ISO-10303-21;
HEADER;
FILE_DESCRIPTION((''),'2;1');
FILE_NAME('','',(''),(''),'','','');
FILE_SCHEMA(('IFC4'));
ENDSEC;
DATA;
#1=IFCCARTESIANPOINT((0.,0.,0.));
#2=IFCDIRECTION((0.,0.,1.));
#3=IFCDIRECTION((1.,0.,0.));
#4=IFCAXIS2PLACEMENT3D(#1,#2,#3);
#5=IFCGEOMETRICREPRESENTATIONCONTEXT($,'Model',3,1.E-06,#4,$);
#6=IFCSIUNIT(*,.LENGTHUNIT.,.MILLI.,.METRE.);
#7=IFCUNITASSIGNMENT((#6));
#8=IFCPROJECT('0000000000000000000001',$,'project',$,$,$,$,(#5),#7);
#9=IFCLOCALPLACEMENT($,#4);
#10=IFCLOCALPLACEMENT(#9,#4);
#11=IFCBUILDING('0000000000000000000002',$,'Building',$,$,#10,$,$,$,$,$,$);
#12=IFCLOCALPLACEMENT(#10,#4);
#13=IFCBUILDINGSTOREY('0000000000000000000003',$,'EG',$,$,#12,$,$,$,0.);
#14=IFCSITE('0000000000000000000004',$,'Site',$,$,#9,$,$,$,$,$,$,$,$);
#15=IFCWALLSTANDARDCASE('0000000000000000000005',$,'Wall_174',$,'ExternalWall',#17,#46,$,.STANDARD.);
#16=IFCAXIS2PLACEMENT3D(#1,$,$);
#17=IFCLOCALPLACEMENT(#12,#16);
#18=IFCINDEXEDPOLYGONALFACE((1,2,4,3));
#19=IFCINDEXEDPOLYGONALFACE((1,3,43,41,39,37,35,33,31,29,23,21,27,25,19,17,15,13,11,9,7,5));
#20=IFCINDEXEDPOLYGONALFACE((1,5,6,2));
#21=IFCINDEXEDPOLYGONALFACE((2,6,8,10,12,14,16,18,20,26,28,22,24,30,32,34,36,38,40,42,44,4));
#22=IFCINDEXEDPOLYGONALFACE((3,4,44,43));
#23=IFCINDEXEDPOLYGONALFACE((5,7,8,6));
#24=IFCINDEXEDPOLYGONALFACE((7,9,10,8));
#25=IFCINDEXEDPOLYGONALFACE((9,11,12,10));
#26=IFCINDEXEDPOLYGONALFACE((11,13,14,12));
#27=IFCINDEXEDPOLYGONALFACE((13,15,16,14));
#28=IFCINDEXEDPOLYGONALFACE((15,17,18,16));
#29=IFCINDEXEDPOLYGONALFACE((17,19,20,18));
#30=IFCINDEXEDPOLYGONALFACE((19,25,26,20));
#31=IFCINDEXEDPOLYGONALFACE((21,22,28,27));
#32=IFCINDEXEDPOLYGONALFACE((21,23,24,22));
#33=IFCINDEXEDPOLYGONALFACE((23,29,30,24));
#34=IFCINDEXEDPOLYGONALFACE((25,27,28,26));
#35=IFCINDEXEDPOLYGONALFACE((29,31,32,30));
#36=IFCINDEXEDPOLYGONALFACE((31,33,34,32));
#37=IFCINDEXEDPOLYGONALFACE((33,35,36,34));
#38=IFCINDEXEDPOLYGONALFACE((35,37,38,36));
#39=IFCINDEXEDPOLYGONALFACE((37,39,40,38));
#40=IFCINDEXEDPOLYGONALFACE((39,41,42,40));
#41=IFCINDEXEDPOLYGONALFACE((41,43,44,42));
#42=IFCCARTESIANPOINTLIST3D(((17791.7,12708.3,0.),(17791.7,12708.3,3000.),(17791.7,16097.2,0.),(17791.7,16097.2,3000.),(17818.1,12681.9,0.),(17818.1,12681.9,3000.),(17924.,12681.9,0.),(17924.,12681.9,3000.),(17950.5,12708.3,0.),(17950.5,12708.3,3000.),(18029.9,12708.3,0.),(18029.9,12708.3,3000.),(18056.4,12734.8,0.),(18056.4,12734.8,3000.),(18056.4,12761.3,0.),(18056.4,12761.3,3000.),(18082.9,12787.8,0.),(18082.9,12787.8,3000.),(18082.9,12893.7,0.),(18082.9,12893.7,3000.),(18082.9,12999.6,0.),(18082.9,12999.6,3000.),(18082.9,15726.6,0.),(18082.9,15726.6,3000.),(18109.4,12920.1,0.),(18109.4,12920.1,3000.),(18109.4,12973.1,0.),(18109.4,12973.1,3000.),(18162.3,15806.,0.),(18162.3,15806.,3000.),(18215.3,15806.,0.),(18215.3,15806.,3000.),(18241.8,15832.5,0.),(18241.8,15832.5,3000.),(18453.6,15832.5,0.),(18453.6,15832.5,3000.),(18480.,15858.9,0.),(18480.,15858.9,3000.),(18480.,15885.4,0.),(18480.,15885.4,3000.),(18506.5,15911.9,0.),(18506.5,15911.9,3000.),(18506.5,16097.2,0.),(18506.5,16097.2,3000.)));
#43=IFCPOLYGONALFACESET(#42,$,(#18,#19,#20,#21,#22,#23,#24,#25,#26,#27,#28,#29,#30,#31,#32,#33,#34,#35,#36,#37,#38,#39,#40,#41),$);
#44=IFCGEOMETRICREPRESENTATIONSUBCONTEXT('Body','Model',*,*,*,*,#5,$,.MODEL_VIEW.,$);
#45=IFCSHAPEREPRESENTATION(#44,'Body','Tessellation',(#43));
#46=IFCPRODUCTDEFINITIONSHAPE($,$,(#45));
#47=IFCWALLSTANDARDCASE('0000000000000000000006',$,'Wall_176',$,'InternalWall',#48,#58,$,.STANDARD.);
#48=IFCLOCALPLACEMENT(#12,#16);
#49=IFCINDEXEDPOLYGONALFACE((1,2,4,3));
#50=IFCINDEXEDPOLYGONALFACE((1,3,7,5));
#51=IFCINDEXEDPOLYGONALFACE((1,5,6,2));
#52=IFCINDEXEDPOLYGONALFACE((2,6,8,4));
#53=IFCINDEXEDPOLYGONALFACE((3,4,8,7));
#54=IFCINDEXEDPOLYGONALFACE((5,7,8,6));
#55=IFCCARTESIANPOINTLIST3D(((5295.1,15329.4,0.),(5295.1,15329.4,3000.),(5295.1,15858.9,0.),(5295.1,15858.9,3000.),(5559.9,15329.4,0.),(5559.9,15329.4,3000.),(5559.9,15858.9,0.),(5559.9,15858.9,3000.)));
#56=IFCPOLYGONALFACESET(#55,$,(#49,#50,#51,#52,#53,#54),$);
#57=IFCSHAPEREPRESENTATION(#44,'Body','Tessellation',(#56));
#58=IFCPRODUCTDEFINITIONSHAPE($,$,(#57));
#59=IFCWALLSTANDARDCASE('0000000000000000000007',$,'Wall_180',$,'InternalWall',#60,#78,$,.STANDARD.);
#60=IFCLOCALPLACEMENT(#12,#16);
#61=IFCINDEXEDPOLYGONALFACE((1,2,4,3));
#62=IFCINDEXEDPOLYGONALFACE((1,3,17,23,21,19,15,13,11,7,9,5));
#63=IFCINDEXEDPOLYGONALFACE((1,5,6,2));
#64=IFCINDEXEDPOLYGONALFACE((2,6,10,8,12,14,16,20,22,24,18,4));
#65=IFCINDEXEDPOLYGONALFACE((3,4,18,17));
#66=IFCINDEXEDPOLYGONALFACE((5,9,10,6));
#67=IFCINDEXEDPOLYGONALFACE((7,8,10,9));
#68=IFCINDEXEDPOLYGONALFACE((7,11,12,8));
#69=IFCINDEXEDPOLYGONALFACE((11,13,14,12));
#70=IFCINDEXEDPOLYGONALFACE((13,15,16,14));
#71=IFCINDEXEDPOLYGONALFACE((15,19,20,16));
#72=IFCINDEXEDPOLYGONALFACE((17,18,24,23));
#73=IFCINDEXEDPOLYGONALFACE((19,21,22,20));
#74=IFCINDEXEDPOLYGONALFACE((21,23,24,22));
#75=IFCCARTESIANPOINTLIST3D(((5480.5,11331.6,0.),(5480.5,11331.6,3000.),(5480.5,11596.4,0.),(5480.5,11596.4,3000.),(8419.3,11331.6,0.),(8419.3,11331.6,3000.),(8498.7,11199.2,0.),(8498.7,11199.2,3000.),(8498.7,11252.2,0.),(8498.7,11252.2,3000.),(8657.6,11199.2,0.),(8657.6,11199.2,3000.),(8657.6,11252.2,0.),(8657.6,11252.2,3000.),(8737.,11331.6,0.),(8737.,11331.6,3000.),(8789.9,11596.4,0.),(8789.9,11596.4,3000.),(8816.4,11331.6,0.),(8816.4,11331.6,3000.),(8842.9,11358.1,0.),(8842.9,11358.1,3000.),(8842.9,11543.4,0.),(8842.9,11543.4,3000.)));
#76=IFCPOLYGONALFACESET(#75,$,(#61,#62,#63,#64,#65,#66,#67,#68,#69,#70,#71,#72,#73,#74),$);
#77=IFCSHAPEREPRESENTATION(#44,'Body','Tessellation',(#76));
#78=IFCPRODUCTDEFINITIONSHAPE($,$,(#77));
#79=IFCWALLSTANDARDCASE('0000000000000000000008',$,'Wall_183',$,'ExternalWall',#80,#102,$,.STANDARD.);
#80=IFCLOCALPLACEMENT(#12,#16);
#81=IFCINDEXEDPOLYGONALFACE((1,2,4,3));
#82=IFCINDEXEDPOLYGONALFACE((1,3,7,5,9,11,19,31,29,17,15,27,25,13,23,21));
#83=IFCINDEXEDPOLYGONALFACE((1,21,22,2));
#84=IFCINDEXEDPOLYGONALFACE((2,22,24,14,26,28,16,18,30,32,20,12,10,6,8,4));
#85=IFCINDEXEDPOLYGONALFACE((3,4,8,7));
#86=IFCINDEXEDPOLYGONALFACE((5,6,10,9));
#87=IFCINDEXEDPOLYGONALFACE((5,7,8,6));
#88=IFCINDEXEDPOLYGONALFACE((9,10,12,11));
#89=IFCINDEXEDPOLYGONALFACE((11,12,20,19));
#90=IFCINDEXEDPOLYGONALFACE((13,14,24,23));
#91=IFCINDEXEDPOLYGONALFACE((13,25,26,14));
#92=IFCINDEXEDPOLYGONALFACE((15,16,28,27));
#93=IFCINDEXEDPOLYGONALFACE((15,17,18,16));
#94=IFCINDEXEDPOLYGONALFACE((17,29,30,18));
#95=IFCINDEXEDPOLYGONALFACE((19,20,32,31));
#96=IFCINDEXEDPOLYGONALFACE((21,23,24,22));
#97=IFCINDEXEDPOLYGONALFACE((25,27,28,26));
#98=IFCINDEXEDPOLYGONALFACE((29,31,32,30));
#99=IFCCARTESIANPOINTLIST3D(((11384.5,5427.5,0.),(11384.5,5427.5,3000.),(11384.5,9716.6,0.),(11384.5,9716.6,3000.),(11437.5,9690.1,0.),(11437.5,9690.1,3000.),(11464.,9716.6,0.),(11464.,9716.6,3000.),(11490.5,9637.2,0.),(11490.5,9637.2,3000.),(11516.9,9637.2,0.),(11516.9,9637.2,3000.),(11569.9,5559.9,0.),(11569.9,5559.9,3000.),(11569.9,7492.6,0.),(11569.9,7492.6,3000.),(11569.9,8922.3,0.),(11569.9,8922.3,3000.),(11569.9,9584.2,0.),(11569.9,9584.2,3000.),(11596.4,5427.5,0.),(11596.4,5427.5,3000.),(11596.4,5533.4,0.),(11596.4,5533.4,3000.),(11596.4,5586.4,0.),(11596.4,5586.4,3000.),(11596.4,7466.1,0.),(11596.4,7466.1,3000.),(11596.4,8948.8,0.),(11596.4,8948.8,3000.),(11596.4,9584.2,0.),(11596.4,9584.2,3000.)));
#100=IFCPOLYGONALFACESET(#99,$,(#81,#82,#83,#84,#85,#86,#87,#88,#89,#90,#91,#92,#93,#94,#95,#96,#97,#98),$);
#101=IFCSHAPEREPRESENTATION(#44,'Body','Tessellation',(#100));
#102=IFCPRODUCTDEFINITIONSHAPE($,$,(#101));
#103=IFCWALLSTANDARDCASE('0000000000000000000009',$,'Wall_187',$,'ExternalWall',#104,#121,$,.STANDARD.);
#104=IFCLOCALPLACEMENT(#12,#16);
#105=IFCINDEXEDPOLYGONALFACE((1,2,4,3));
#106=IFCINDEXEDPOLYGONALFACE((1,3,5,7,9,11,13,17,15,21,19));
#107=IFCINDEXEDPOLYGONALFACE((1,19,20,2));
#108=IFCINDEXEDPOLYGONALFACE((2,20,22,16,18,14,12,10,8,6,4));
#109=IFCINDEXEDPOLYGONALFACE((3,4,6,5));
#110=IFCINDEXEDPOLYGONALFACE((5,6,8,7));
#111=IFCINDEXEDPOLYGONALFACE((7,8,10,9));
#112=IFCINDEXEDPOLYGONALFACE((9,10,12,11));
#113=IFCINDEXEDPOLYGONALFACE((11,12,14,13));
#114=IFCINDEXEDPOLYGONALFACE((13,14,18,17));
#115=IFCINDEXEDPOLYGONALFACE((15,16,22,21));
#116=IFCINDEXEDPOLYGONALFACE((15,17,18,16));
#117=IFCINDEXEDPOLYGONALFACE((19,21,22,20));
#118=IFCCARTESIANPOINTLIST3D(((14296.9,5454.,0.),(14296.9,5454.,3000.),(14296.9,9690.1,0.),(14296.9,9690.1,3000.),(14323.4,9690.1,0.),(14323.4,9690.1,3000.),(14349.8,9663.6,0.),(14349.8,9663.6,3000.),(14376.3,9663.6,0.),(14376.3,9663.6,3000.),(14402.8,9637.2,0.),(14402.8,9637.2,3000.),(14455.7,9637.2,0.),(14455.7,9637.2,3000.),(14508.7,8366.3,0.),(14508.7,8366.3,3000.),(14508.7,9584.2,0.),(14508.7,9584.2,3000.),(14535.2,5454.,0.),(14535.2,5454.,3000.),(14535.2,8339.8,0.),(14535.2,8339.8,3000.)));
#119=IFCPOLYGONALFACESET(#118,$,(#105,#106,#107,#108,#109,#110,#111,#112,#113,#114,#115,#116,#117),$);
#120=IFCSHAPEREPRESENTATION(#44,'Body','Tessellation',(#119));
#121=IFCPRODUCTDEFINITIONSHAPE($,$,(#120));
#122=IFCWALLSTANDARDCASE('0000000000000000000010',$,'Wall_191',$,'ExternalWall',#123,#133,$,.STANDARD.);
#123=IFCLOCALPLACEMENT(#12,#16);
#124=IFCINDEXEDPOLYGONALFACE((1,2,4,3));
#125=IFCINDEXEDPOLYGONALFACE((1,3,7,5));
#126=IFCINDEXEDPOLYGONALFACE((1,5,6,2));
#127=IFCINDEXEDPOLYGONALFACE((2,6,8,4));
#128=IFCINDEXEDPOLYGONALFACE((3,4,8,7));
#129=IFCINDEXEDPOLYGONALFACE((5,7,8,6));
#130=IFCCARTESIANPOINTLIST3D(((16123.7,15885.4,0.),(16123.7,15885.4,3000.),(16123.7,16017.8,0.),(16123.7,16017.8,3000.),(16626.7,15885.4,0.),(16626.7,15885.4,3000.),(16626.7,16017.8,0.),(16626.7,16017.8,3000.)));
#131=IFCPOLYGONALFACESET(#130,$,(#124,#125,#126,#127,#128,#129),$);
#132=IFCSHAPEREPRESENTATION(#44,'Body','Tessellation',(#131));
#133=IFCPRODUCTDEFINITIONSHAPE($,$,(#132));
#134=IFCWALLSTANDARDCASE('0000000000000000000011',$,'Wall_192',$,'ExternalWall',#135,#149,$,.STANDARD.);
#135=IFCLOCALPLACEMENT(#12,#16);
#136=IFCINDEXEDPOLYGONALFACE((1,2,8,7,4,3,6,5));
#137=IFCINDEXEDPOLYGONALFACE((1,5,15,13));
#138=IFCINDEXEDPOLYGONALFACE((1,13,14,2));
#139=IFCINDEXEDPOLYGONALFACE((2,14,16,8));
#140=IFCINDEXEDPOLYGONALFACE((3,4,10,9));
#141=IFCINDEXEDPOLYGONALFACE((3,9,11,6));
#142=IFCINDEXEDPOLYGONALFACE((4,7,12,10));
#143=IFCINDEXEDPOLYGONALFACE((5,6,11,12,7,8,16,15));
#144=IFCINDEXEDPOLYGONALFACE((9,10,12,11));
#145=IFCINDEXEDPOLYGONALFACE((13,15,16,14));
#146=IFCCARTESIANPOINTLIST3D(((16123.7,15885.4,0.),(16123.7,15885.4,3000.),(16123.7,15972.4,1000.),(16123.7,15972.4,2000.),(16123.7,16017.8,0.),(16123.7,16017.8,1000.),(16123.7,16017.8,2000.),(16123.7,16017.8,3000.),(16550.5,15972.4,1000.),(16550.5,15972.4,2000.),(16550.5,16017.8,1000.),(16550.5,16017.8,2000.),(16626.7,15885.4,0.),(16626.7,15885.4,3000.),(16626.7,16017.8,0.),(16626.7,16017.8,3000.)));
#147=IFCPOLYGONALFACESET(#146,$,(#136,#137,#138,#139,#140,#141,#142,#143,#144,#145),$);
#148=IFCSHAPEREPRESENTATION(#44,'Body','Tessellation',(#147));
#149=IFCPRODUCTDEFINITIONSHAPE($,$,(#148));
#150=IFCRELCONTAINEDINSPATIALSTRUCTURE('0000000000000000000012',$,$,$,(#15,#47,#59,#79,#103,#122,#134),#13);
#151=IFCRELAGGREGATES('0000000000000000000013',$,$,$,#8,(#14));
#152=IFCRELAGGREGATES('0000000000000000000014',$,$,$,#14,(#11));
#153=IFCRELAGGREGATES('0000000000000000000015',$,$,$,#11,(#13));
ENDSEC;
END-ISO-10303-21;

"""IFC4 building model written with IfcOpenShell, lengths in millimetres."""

from ifc_helpers import new_model, si_unit, frame, origin_with_axes, place, context, subcontext, project, spatial, polyline, rectangle, outline, extrude, element, save


model = new_model("IFC4")

# Units and contexts
model_context = context("Model", 3, precision=1e-06, world=origin_with_axes())
body_context = subcontext(model_context, "Body", "Model", "MODEL_VIEW")
ifc_project = project(units=[si_unit("LENGTHUNIT", "METRE", prefix="MILLI")], contexts=[model_context])

# Site, building, storey
site_placement = place(None, origin_with_axes())
site = spatial("IfcSite", under=ifc_project, at=site_placement, Name="Site")
building_placement = place(site_placement, origin_with_axes())
building = spatial("IfcBuilding", under=site, at=building_placement, Name="Building")
storey_placement = place(building_placement, origin_with_axes())
storey = spatial("IfcBuildingStorey", under=building, at=storey_placement, Name="EG", Elevation=0.0)

# Walls
for number, where, z_axis, x_axis, name in (
    (1, (0.0, 0.0, 0.0), (0.0, 0.0, 1.0), (1.0, 0.0, 0.0), "Wall_174"),
):
    element("IfcWallStandardCase", number, at=place(storey_placement, frame(where, z_axis=z_axis, x_axis=x_axis)), inside=storey, Name=name, ObjectType="ExternalWall", PredefinedType="STANDARD", context=body_context, shape_type="SweptSolid", body=[
        extrude(outline(polyline([(17818.1, 12681.9, 0.0), (17791.7, 12708.3, 0.0), (17791.7, 16097.2, 0.0), (18506.5, 16097.2, 0.0), (18506.5, 15911.9, 0.0), (18480.0, 15885.4, 0.0), (18480.0, 15858.9, 0.0), (18453.6, 15832.5, 0.0), (18241.8, 15832.5, 0.0), (18215.3, 15806.0, 0.0), (18162.3, 15806.0, 0.0), (18082.9, 15726.6, 0.0), (18082.9, 12999.6, 0.0), (18109.4, 12973.1, 0.0), (18109.4, 12920.1, 0.0), (18082.9, 12893.7, 0.0), (18082.9, 12787.8, 0.0), (18056.4, 12761.3, 0.0), (18056.4, 12734.8, 0.0), (18029.9, 12708.3, 0.0), (17950.5, 12708.3, 0.0), (17924.0, 12681.9, 0.0), (17818.1, 12681.9, 0.0)])), origin_with_axes(), (0.0, 0.0, 1.0), 3000.0),
    ])
for number, where, z_axis, x_axis, name in (
    (2, (0.0, 0.0, 0.0), (0.0, 0.0, 1.0), (1.0, 0.0, 0.0), "Wall_176"),
):
    element("IfcWallStandardCase", number, at=place(storey_placement, frame(where, z_axis=z_axis, x_axis=x_axis)), inside=storey, Name=name, ObjectType="InternalWall", PredefinedType="STANDARD", context=body_context, shape_type="SweptSolid", body=[
        extrude(outline(polyline([(5295.1, 15329.4, 0.0), (5295.1, 15858.9, 0.0), (5559.9, 15858.9, 0.0), (5559.9, 15329.4, 0.0), (5295.1, 15329.4, 0.0)])), origin_with_axes(), (0.0, 0.0, 1.0), 3000.0),
    ])
for number, where, z_axis, x_axis, name in (
    (3, (0.0, 0.0, 0.0), (0.0, 0.0, 1.0), (1.0, 0.0, 0.0), "Wall_180"),
):
    element("IfcWallStandardCase", number, at=place(storey_placement, frame(where, z_axis=z_axis, x_axis=x_axis)), inside=storey, Name=name, ObjectType="InternalWall", PredefinedType="STANDARD", context=body_context, shape_type="SweptSolid", body=[
        extrude(outline(polyline([(8498.7, 11199.2, 0.0), (8498.7, 11252.2, 0.0), (8419.3, 11331.6, 0.0), (5480.5, 11331.6, 0.0), (5480.5, 11596.4, 0.0), (8789.9, 11596.4, 0.0), (8842.9, 11543.4, 0.0), (8842.9, 11358.1, 0.0), (8816.4, 11331.6, 0.0), (8737.0, 11331.6, 0.0), (8657.6, 11252.2, 0.0), (8657.6, 11199.2, 0.0), (8498.7, 11199.2, 0.0)])), origin_with_axes(), (0.0, 0.0, 1.0), 3000.0),
    ])
for number, where, z_axis, x_axis, name in (
    (4, (0.0, 0.0, 0.0), (0.0, 0.0, 1.0), (1.0, 0.0, 0.0), "Wall_183"),
):
    element("IfcWallStandardCase", number, at=place(storey_placement, frame(where, z_axis=z_axis, x_axis=x_axis)), inside=storey, Name=name, ObjectType="ExternalWall", PredefinedType="STANDARD", context=body_context, shape_type="SweptSolid", body=[
        extrude(outline(polyline([(11384.5, 5427.5, 0.0), (11384.5, 9716.6, 0.0), (11464.0, 9716.6, 0.0), (11437.5, 9690.1, 0.0), (11490.5, 9637.2, 0.0), (11516.9, 9637.2, 0.0), (11569.9, 9584.2, 0.0), (11596.4, 9584.2, 0.0), (11596.4, 8948.8, 0.0), (11569.9, 8922.3, 0.0), (11569.9, 7492.6, 0.0), (11596.4, 7466.1, 0.0), (11596.4, 5586.4, 0.0), (11569.9, 5559.9, 0.0), (11596.4, 5533.4, 0.0), (11596.4, 5427.5, 0.0), (11384.5, 5427.5, 0.0)])), origin_with_axes(), (0.0, 0.0, 1.0), 3000.0),
    ])
for number, where, z_axis, x_axis, name in (
    (5, (0.0, 0.0, 0.0), (0.0, 0.0, 1.0), (1.0, 0.0, 0.0), "Wall_187"),
):
    element("IfcWallStandardCase", number, at=place(storey_placement, frame(where, z_axis=z_axis, x_axis=x_axis)), inside=storey, Name=name, ObjectType="ExternalWall", PredefinedType="STANDARD", context=body_context, shape_type="SweptSolid", body=[
        extrude(outline(polyline([(14296.9, 5454.0, 0.0), (14296.9, 9690.1, 0.0), (14323.4, 9690.1, 0.0), (14349.8, 9663.6, 0.0), (14376.3, 9663.6, 0.0), (14402.8, 9637.2, 0.0), (14455.7, 9637.2, 0.0), (14508.7, 9584.2, 0.0), (14508.7, 8366.3, 0.0), (14535.2, 8339.8, 0.0), (14535.2, 5454.0, 0.0), (14296.9, 5454.0, 0.0)])), origin_with_axes(), (0.0, 0.0, 1.0), 3000.0),
    ])
wall_1_placement = place(storey_placement, origin_with_axes())
element("IfcWallStandardCase", 6, at=wall_1_placement, inside=storey, Name="Wall_191", ObjectType="ExternalWall", PredefinedType="STANDARD", context=body_context, shape_type="SweptSolid", body=[
    extrude(outline(polyline([(16123.7, 15885.4, 0.0), (16123.7, 16017.8, 0.0), (16626.7, 16017.8, 0.0), (16626.7, 15885.4, 0.0), (16123.7, 15885.4, 0.0)])), origin_with_axes(), (0.0, 0.0, 1.0), 3000.0),
])

# Wall, opening
wall_2_placement = place(storey_placement, origin_with_axes())
wall_2 = element("IfcWallStandardCase", 7, at=wall_2_placement, inside=storey, Name="Wall_192", ObjectType="ExternalWall", PredefinedType="STANDARD", context=body_context, shape_type="SweptSolid", body=[
    extrude(outline(polyline([(16123.7, 15885.4, 0.0), (16123.7, 16017.8, 0.0), (16626.7, 16017.8, 0.0), (16626.7, 15885.4, 0.0), (16123.7, 15885.4, 0.0)])), origin_with_axes(), (0.0, 0.0, 1.0), 3000.0),
])
opening_placement = place(wall_2_placement, origin_with_axes())
element("IfcOpeningElement", 8, at=opening_placement, inside=storey, cuts=wall_2, context=body_context, shape_type="SweptSolid", body=[
    extrude(rectangle(XDim=842.5, YDim=115.0), frame((16129.3, 16029.9, 1000.0), z_axis=(0.0, 0.0, 1.0), x_axis=(1.0, 0.0, 0.0)), (0.0, 0.0, 1.0), 1000.0),
])

save(model, "model.ifc")
